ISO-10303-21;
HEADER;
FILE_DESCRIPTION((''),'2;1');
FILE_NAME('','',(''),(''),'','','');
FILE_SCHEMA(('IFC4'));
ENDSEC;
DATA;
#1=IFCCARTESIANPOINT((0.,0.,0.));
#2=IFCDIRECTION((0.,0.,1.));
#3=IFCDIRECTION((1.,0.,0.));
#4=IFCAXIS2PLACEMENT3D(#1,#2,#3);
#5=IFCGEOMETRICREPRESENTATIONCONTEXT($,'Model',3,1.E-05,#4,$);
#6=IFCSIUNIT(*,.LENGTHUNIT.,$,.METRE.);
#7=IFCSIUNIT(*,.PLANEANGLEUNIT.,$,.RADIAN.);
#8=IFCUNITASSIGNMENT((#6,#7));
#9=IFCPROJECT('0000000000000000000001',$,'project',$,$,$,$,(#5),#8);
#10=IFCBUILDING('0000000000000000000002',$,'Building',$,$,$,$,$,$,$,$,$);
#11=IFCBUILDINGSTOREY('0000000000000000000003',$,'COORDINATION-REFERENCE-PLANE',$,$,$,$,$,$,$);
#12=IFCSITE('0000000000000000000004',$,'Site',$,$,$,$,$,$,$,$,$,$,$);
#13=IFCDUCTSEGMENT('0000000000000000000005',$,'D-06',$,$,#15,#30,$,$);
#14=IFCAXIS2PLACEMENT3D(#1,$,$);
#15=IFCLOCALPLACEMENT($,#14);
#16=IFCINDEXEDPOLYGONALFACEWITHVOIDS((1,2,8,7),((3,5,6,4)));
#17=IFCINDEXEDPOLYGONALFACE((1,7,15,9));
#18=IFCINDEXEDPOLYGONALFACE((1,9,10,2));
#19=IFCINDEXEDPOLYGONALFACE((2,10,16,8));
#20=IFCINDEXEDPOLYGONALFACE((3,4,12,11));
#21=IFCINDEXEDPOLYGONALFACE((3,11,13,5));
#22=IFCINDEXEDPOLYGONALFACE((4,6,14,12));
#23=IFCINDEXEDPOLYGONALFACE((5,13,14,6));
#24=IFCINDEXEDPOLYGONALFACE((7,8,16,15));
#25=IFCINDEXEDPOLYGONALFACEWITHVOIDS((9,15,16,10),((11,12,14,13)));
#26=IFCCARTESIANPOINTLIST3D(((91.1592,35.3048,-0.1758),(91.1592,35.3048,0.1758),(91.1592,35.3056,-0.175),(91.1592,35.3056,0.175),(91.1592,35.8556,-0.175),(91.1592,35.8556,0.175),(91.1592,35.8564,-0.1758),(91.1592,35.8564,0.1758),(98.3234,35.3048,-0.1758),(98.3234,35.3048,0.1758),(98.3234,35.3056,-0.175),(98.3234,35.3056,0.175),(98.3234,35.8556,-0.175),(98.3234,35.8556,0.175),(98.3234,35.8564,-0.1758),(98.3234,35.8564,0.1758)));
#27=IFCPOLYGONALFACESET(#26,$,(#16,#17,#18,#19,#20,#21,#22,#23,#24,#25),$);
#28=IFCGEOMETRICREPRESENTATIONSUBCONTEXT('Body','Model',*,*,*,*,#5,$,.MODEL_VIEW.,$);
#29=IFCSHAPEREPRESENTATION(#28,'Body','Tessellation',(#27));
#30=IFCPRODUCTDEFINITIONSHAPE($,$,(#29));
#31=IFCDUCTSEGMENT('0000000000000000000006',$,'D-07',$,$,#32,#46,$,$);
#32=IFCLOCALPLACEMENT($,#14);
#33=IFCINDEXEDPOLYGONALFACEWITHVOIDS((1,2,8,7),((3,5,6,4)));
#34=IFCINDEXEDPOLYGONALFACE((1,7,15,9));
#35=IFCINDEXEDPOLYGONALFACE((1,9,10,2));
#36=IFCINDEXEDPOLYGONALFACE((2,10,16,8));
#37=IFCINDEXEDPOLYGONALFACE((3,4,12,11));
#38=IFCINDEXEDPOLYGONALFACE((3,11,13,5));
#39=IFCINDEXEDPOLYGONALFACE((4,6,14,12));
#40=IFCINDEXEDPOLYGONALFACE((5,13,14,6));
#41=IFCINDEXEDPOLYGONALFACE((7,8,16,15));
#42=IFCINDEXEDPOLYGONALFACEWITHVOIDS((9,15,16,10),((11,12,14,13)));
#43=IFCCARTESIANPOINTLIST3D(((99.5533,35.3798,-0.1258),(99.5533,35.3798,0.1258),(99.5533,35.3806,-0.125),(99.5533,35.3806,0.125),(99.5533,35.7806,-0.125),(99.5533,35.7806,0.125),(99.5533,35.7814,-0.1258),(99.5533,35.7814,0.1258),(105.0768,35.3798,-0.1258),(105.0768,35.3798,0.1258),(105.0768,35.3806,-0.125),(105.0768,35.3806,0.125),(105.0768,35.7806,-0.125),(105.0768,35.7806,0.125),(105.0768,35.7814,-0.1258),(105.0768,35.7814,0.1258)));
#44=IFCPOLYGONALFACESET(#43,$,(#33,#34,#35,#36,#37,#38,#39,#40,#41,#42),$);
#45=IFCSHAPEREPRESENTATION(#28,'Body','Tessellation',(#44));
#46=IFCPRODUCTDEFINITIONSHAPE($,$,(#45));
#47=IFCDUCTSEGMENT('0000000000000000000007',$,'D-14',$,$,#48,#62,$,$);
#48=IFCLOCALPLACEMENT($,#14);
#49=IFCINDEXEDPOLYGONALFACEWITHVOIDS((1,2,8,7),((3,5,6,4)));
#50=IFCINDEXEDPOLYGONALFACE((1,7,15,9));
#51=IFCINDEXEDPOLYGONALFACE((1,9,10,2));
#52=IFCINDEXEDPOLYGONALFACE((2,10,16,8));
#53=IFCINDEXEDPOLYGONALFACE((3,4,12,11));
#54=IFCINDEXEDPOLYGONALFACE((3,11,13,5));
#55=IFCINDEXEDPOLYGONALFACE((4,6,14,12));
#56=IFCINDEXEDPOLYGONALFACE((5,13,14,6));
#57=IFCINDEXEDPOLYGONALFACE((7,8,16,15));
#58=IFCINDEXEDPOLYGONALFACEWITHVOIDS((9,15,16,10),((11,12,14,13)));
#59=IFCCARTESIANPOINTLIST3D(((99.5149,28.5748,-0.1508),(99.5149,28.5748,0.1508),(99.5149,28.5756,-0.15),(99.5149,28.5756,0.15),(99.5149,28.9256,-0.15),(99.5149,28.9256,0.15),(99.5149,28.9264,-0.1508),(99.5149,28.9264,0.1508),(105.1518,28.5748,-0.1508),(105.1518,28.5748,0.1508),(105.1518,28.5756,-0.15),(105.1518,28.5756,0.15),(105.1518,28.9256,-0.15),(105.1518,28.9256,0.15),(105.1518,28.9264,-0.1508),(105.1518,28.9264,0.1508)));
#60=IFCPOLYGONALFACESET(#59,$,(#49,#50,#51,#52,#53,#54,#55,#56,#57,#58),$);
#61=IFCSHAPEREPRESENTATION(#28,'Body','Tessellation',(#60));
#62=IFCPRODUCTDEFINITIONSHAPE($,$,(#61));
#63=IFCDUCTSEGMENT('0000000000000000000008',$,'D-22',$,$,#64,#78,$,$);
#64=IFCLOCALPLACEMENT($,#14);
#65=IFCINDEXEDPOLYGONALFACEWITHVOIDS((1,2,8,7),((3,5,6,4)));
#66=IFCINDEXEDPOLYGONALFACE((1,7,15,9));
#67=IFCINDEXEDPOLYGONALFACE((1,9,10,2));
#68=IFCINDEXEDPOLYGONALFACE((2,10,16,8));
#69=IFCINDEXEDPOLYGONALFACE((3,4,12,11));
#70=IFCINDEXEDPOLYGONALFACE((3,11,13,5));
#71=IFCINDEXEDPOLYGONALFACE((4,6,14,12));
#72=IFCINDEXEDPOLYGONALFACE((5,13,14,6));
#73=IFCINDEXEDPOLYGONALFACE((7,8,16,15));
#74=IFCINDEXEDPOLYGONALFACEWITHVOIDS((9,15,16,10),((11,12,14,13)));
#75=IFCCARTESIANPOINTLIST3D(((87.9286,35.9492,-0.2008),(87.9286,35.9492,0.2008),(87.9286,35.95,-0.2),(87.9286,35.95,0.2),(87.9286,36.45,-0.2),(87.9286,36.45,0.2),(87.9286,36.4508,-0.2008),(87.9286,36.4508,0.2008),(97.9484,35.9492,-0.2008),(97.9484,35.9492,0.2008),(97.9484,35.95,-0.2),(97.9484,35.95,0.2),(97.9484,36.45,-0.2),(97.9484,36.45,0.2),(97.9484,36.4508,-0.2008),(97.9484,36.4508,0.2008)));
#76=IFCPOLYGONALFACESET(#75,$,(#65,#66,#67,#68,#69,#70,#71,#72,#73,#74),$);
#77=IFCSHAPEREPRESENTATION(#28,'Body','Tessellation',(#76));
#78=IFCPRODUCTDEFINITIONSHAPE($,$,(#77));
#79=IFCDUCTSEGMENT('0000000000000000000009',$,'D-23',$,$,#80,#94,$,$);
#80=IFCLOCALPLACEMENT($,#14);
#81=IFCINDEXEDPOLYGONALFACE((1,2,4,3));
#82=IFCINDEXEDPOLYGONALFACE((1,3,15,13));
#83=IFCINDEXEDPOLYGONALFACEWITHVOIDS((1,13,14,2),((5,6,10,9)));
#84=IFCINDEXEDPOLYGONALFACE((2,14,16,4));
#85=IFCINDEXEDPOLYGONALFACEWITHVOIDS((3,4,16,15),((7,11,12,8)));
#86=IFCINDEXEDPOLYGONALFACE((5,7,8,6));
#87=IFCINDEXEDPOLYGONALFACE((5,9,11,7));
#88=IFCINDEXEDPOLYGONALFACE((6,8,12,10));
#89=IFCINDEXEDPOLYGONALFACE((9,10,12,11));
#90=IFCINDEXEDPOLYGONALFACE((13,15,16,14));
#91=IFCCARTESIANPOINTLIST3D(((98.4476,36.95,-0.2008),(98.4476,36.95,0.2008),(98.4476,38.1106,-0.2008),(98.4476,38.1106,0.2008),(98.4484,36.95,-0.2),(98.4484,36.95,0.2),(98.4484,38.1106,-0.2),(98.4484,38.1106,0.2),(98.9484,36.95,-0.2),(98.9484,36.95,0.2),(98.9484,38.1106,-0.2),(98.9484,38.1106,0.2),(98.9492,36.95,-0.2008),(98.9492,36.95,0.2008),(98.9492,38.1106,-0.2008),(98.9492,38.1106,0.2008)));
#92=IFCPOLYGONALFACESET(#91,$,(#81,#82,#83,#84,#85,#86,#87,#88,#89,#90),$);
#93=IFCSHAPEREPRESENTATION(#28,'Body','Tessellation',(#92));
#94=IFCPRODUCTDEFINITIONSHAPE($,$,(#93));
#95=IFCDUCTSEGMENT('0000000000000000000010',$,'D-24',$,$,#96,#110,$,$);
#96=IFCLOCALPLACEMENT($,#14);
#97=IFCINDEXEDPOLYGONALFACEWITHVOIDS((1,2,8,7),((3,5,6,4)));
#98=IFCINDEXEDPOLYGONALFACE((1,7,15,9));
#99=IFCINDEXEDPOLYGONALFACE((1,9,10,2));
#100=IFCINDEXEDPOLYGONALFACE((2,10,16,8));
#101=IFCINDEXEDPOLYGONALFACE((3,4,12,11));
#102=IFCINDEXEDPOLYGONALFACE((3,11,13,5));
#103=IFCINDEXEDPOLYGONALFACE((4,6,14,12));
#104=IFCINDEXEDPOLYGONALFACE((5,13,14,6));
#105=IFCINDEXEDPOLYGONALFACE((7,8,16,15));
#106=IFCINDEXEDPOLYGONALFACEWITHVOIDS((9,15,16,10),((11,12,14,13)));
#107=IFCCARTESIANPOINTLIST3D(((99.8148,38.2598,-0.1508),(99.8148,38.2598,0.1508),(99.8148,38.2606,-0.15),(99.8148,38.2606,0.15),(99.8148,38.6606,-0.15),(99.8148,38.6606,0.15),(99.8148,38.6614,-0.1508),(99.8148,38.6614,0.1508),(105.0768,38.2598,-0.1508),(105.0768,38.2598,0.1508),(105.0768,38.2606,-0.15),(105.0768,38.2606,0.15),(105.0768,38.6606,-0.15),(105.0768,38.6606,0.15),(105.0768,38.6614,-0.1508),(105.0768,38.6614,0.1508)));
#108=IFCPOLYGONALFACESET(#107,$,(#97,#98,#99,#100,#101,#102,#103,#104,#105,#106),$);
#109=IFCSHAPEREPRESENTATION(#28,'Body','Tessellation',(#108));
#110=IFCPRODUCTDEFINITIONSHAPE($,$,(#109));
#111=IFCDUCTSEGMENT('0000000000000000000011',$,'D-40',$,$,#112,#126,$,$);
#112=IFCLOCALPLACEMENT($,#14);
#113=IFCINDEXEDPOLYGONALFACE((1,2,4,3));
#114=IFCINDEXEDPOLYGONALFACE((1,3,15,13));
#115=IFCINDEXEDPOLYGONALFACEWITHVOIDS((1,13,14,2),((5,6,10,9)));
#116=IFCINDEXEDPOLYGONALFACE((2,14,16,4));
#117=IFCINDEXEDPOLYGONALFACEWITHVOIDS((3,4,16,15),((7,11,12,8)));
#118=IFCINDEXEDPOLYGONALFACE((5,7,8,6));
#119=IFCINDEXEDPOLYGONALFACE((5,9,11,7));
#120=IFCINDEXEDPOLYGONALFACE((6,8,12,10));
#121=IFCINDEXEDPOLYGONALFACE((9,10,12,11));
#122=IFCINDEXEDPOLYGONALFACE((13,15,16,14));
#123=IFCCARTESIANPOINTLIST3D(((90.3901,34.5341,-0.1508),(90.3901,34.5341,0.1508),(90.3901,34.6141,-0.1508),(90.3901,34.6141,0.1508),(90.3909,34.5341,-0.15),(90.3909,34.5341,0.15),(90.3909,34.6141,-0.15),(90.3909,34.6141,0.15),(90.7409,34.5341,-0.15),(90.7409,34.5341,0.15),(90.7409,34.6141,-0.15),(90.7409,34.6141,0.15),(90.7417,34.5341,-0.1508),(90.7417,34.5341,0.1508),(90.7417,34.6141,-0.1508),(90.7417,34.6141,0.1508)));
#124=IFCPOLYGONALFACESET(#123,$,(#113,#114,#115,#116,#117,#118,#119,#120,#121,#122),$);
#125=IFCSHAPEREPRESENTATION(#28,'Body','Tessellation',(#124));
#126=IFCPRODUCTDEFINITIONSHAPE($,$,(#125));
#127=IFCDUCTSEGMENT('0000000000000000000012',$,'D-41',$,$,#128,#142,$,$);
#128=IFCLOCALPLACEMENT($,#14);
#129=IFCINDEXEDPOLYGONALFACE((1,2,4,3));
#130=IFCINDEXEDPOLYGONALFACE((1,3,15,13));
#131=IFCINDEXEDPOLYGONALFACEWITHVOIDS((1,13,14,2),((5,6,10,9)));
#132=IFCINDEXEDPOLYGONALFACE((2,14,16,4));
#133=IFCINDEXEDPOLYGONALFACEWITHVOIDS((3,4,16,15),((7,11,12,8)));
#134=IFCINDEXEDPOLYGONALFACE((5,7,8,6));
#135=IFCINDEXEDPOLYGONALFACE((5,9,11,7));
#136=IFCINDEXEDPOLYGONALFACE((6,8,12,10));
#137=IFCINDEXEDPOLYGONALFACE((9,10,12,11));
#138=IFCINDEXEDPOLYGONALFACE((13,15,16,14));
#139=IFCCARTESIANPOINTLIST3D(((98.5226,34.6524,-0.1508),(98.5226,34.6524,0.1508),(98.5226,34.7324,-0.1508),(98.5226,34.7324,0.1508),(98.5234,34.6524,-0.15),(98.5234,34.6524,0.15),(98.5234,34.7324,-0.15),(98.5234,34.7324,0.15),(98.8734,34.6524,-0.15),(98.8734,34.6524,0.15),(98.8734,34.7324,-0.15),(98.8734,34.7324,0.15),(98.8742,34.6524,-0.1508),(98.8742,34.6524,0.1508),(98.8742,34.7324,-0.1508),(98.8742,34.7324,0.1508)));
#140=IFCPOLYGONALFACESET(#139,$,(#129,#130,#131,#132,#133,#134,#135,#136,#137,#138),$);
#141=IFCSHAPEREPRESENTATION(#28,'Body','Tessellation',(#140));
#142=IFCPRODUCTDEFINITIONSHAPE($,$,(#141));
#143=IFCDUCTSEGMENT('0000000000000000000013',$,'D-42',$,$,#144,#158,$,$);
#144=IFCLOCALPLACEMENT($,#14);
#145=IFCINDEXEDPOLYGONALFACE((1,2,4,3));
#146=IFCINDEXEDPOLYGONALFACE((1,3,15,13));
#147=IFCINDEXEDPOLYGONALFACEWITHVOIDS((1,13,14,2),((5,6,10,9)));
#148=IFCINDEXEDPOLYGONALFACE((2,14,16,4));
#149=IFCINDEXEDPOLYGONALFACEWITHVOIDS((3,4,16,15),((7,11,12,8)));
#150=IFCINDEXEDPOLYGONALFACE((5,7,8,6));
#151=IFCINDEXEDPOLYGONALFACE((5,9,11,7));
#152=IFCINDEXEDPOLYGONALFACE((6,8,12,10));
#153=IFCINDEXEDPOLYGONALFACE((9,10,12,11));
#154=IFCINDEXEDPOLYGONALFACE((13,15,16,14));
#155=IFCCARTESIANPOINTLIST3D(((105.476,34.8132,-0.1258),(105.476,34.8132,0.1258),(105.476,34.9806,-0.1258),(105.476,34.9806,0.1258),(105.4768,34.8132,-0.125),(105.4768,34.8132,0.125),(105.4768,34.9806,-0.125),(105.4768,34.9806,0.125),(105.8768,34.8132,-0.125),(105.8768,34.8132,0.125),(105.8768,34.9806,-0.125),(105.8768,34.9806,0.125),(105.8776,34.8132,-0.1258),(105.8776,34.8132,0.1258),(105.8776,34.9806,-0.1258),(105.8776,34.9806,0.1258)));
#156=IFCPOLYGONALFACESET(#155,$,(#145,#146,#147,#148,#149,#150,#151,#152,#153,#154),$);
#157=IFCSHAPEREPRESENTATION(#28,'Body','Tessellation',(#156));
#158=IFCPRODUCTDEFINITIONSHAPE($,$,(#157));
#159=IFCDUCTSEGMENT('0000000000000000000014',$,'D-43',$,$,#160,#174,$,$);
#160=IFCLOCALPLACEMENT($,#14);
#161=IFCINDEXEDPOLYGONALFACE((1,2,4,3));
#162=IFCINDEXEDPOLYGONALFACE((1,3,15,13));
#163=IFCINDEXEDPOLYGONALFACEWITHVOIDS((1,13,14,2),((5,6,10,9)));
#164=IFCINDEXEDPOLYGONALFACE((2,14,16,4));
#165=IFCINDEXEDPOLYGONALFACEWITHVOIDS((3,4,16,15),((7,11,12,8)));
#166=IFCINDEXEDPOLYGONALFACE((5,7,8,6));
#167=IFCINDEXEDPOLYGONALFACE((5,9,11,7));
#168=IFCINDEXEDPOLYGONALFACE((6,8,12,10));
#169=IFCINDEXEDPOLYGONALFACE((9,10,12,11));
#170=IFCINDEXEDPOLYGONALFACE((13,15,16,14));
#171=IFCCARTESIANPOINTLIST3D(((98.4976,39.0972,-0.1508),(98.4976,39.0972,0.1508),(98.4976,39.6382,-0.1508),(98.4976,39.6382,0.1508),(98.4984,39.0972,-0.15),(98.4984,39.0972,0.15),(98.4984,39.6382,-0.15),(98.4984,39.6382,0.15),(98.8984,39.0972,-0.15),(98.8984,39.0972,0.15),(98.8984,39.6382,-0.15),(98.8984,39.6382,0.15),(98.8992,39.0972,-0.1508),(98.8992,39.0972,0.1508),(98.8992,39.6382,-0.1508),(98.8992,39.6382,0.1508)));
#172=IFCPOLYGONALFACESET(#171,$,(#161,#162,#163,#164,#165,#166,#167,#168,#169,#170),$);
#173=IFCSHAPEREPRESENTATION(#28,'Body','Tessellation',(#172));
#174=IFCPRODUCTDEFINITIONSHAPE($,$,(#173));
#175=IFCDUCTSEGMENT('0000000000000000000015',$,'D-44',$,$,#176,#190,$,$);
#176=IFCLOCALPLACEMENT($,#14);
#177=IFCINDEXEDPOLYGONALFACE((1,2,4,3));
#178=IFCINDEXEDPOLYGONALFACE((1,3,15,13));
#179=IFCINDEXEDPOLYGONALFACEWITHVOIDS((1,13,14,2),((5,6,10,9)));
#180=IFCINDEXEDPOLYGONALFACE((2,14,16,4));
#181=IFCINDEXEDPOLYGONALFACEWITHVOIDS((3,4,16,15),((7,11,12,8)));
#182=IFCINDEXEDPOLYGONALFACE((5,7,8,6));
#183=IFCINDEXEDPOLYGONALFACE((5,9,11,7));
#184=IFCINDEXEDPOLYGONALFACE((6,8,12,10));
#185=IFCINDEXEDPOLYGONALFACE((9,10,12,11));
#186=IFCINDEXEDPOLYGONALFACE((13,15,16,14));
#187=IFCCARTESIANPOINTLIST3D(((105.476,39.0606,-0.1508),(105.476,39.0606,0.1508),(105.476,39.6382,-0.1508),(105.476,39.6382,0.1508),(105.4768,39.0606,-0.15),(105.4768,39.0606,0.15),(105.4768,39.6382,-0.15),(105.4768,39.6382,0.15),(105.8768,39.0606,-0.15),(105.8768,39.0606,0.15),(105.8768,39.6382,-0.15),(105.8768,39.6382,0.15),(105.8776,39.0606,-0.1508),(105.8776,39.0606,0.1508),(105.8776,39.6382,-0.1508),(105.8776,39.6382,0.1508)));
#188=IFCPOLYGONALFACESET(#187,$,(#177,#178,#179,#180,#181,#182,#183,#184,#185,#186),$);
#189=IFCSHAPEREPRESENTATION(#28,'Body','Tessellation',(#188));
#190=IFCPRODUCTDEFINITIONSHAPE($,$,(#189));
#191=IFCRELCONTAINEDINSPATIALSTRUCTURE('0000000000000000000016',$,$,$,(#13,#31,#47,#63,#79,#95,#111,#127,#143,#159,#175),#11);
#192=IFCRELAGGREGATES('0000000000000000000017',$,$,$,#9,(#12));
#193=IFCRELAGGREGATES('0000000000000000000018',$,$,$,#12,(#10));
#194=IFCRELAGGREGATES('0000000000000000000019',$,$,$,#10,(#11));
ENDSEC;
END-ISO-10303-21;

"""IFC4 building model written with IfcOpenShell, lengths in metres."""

from ifc_helpers import new_model, si_unit, frame, origin, origin_with_axes, place, context, subcontext, project, spatial, hollow_rectangle, extrude, element, save


model = new_model("IFC4")

# Units and contexts
model_context = context("Model", 3, precision=1e-05, world=origin_with_axes())
body_context_1 = subcontext(model_context, "Body", "Model", "MODEL_VIEW")
ifc_project = project(units=[si_unit("LENGTHUNIT", "METRE"), si_unit("PLANEANGLEUNIT", "RADIAN")], contexts=[model_context])

# Site, building, storey
site = spatial("IfcSite", under=ifc_project, Name="Site")
building = spatial("IfcBuilding", under=site, Name="Building")
storey = spatial("IfcBuildingStorey", under=building, Name="COORDINATION-REFERENCE-PLANE")

# Duct segments
duct_segment_1_placement = place(None, frame((91.1592, 35.5806, 0.0), z_axis=(1.0, 0.0, 0.0), x_axis=(0.0, 1.0, 0.0)))
element("IfcDuctSegment", 1, at=duct_segment_1_placement, inside=storey, Name="D-06", context=body_context_1, shape_type="SweptSolid", body=[
    extrude(hollow_rectangle(XDim=0.5516, YDim=0.3516, WallThickness=0.0008), origin(), (0.0, 0.0, 1.0), 7.1642),
])
duct_segment_2_placement = place(None, frame((99.5533, 35.5806, 0.0), z_axis=(1.0, 0.0, 0.0), x_axis=(0.0, 1.0, 0.0)))
element("IfcDuctSegment", 2, at=duct_segment_2_placement, inside=storey, Name="D-07", context=body_context_1, shape_type="SweptSolid", body=[
    extrude(hollow_rectangle(XDim=0.4016, YDim=0.2516, WallThickness=0.0008), origin(), (0.0, 0.0, 1.0), 5.5234),
])
duct_segment_3_placement = place(None, frame((99.5149, 28.7506, 0.0), z_axis=(1.0, 0.0, 0.0), x_axis=(0.0, 1.0, 0.0)))
element("IfcDuctSegment", 3, at=duct_segment_3_placement, inside=storey, Name="D-14", context=body_context_1, shape_type="SweptSolid", body=[
    extrude(hollow_rectangle(XDim=0.3516, YDim=0.3016, WallThickness=0.0008), origin(), (0.0, 0.0, 1.0), 5.6369),
])
duct_segment_4_placement = place(None, frame((87.9286, 36.2, 0.0), z_axis=(1.0, 0.0, 0.0), x_axis=(0.0, 1.0, 0.0)))
element("IfcDuctSegment", 4, at=duct_segment_4_placement, inside=storey, Name="D-22", context=body_context_1, shape_type="SweptSolid", body=[
    extrude(hollow_rectangle(XDim=0.5016, YDim=0.4016, WallThickness=0.0008), origin(), (0.0, 0.0, 1.0), 10.0199),
])
duct_segment_5_placement = place(None, frame((98.6984, 36.95, 0.0), z_axis=(0.0, 1.0, 0.0), x_axis=(1.0, 0.0, 0.0)))
element("IfcDuctSegment", 5, at=duct_segment_5_placement, inside=storey, Name="D-23", context=body_context_1, shape_type="SweptSolid", body=[
    extrude(hollow_rectangle(XDim=0.5016, YDim=0.4016, WallThickness=0.0008), origin(), (0.0, 0.0, 1.0), 1.1606),
])
duct_segment_6_placement = place(None, frame((99.8148, 38.4606, 0.0), z_axis=(1.0, 0.0, 0.0), x_axis=(0.0, 1.0, 0.0)))
element("IfcDuctSegment", 6, at=duct_segment_6_placement, inside=storey, Name="D-24", context=body_context_1, shape_type="SweptSolid", body=[
    extrude(hollow_rectangle(XDim=0.4016, YDim=0.3016, WallThickness=0.0008), origin(), (0.0, 0.0, 1.0), 5.2619),
])
for number, where, z_axis, x_axis, name in (
    (7, (90.5659, 34.5341, 0.0), (0.0, 1.0, 0.0), (1.0, 0.0, 0.0), "D-40"),
    (8, (98.6984, 34.6524, 0.0), (0.0, 1.0, 0.0), (1.0, 0.0, 0.0), "D-41"),
):
    element("IfcDuctSegment", number, at=place(None, frame(where, z_axis=z_axis, x_axis=x_axis)), inside=storey, Name=name, context=body_context_1, shape_type="SweptSolid", body=[
        extrude(hollow_rectangle(XDim=0.3516, YDim=0.3016, WallThickness=0.0008), origin(), (0.0, 0.0, 1.0), 0.08),
    ])
duct_segment_7_placement = place(None, frame((105.6768, 34.8132, 0.0), z_axis=(0.0, 1.0, 0.0), x_axis=(1.0, 0.0, 0.0)))
element("IfcDuctSegment", 9, at=duct_segment_7_placement, inside=storey, Name="D-42", context=body_context_1, shape_type="SweptSolid", body=[
    extrude(hollow_rectangle(XDim=0.4016, YDim=0.2516, WallThickness=0.0008), origin(), (0.0, 0.0, 1.0), 0.1673),
])
duct_segment_8_placement = place(None, frame((98.6984, 39.0972, 0.0), z_axis=(0.0, 1.0, 0.0), x_axis=(1.0, 0.0, 0.0)))
element("IfcDuctSegment", 10, at=duct_segment_8_placement, inside=storey, Name="D-43", context=body_context_1, shape_type="SweptSolid", body=[
    extrude(hollow_rectangle(XDim=0.4016, YDim=0.3016, WallThickness=0.0008), origin(), (0.0, 0.0, 1.0), 0.541),
])
duct_segment_9_placement = place(None, frame((105.6768, 39.0606, 0.0), z_axis=(0.0, 1.0, 0.0), x_axis=(1.0, 0.0, 0.0)))
element("IfcDuctSegment", 11, at=duct_segment_9_placement, inside=storey, Name="D-44", context=body_context_1, shape_type="SweptSolid", body=[
    extrude(hollow_rectangle(XDim=0.4016, YDim=0.3016, WallThickness=0.0008), origin(), (0.0, 0.0, 1.0), 0.5776),
])

save(model, "model.ifc")
